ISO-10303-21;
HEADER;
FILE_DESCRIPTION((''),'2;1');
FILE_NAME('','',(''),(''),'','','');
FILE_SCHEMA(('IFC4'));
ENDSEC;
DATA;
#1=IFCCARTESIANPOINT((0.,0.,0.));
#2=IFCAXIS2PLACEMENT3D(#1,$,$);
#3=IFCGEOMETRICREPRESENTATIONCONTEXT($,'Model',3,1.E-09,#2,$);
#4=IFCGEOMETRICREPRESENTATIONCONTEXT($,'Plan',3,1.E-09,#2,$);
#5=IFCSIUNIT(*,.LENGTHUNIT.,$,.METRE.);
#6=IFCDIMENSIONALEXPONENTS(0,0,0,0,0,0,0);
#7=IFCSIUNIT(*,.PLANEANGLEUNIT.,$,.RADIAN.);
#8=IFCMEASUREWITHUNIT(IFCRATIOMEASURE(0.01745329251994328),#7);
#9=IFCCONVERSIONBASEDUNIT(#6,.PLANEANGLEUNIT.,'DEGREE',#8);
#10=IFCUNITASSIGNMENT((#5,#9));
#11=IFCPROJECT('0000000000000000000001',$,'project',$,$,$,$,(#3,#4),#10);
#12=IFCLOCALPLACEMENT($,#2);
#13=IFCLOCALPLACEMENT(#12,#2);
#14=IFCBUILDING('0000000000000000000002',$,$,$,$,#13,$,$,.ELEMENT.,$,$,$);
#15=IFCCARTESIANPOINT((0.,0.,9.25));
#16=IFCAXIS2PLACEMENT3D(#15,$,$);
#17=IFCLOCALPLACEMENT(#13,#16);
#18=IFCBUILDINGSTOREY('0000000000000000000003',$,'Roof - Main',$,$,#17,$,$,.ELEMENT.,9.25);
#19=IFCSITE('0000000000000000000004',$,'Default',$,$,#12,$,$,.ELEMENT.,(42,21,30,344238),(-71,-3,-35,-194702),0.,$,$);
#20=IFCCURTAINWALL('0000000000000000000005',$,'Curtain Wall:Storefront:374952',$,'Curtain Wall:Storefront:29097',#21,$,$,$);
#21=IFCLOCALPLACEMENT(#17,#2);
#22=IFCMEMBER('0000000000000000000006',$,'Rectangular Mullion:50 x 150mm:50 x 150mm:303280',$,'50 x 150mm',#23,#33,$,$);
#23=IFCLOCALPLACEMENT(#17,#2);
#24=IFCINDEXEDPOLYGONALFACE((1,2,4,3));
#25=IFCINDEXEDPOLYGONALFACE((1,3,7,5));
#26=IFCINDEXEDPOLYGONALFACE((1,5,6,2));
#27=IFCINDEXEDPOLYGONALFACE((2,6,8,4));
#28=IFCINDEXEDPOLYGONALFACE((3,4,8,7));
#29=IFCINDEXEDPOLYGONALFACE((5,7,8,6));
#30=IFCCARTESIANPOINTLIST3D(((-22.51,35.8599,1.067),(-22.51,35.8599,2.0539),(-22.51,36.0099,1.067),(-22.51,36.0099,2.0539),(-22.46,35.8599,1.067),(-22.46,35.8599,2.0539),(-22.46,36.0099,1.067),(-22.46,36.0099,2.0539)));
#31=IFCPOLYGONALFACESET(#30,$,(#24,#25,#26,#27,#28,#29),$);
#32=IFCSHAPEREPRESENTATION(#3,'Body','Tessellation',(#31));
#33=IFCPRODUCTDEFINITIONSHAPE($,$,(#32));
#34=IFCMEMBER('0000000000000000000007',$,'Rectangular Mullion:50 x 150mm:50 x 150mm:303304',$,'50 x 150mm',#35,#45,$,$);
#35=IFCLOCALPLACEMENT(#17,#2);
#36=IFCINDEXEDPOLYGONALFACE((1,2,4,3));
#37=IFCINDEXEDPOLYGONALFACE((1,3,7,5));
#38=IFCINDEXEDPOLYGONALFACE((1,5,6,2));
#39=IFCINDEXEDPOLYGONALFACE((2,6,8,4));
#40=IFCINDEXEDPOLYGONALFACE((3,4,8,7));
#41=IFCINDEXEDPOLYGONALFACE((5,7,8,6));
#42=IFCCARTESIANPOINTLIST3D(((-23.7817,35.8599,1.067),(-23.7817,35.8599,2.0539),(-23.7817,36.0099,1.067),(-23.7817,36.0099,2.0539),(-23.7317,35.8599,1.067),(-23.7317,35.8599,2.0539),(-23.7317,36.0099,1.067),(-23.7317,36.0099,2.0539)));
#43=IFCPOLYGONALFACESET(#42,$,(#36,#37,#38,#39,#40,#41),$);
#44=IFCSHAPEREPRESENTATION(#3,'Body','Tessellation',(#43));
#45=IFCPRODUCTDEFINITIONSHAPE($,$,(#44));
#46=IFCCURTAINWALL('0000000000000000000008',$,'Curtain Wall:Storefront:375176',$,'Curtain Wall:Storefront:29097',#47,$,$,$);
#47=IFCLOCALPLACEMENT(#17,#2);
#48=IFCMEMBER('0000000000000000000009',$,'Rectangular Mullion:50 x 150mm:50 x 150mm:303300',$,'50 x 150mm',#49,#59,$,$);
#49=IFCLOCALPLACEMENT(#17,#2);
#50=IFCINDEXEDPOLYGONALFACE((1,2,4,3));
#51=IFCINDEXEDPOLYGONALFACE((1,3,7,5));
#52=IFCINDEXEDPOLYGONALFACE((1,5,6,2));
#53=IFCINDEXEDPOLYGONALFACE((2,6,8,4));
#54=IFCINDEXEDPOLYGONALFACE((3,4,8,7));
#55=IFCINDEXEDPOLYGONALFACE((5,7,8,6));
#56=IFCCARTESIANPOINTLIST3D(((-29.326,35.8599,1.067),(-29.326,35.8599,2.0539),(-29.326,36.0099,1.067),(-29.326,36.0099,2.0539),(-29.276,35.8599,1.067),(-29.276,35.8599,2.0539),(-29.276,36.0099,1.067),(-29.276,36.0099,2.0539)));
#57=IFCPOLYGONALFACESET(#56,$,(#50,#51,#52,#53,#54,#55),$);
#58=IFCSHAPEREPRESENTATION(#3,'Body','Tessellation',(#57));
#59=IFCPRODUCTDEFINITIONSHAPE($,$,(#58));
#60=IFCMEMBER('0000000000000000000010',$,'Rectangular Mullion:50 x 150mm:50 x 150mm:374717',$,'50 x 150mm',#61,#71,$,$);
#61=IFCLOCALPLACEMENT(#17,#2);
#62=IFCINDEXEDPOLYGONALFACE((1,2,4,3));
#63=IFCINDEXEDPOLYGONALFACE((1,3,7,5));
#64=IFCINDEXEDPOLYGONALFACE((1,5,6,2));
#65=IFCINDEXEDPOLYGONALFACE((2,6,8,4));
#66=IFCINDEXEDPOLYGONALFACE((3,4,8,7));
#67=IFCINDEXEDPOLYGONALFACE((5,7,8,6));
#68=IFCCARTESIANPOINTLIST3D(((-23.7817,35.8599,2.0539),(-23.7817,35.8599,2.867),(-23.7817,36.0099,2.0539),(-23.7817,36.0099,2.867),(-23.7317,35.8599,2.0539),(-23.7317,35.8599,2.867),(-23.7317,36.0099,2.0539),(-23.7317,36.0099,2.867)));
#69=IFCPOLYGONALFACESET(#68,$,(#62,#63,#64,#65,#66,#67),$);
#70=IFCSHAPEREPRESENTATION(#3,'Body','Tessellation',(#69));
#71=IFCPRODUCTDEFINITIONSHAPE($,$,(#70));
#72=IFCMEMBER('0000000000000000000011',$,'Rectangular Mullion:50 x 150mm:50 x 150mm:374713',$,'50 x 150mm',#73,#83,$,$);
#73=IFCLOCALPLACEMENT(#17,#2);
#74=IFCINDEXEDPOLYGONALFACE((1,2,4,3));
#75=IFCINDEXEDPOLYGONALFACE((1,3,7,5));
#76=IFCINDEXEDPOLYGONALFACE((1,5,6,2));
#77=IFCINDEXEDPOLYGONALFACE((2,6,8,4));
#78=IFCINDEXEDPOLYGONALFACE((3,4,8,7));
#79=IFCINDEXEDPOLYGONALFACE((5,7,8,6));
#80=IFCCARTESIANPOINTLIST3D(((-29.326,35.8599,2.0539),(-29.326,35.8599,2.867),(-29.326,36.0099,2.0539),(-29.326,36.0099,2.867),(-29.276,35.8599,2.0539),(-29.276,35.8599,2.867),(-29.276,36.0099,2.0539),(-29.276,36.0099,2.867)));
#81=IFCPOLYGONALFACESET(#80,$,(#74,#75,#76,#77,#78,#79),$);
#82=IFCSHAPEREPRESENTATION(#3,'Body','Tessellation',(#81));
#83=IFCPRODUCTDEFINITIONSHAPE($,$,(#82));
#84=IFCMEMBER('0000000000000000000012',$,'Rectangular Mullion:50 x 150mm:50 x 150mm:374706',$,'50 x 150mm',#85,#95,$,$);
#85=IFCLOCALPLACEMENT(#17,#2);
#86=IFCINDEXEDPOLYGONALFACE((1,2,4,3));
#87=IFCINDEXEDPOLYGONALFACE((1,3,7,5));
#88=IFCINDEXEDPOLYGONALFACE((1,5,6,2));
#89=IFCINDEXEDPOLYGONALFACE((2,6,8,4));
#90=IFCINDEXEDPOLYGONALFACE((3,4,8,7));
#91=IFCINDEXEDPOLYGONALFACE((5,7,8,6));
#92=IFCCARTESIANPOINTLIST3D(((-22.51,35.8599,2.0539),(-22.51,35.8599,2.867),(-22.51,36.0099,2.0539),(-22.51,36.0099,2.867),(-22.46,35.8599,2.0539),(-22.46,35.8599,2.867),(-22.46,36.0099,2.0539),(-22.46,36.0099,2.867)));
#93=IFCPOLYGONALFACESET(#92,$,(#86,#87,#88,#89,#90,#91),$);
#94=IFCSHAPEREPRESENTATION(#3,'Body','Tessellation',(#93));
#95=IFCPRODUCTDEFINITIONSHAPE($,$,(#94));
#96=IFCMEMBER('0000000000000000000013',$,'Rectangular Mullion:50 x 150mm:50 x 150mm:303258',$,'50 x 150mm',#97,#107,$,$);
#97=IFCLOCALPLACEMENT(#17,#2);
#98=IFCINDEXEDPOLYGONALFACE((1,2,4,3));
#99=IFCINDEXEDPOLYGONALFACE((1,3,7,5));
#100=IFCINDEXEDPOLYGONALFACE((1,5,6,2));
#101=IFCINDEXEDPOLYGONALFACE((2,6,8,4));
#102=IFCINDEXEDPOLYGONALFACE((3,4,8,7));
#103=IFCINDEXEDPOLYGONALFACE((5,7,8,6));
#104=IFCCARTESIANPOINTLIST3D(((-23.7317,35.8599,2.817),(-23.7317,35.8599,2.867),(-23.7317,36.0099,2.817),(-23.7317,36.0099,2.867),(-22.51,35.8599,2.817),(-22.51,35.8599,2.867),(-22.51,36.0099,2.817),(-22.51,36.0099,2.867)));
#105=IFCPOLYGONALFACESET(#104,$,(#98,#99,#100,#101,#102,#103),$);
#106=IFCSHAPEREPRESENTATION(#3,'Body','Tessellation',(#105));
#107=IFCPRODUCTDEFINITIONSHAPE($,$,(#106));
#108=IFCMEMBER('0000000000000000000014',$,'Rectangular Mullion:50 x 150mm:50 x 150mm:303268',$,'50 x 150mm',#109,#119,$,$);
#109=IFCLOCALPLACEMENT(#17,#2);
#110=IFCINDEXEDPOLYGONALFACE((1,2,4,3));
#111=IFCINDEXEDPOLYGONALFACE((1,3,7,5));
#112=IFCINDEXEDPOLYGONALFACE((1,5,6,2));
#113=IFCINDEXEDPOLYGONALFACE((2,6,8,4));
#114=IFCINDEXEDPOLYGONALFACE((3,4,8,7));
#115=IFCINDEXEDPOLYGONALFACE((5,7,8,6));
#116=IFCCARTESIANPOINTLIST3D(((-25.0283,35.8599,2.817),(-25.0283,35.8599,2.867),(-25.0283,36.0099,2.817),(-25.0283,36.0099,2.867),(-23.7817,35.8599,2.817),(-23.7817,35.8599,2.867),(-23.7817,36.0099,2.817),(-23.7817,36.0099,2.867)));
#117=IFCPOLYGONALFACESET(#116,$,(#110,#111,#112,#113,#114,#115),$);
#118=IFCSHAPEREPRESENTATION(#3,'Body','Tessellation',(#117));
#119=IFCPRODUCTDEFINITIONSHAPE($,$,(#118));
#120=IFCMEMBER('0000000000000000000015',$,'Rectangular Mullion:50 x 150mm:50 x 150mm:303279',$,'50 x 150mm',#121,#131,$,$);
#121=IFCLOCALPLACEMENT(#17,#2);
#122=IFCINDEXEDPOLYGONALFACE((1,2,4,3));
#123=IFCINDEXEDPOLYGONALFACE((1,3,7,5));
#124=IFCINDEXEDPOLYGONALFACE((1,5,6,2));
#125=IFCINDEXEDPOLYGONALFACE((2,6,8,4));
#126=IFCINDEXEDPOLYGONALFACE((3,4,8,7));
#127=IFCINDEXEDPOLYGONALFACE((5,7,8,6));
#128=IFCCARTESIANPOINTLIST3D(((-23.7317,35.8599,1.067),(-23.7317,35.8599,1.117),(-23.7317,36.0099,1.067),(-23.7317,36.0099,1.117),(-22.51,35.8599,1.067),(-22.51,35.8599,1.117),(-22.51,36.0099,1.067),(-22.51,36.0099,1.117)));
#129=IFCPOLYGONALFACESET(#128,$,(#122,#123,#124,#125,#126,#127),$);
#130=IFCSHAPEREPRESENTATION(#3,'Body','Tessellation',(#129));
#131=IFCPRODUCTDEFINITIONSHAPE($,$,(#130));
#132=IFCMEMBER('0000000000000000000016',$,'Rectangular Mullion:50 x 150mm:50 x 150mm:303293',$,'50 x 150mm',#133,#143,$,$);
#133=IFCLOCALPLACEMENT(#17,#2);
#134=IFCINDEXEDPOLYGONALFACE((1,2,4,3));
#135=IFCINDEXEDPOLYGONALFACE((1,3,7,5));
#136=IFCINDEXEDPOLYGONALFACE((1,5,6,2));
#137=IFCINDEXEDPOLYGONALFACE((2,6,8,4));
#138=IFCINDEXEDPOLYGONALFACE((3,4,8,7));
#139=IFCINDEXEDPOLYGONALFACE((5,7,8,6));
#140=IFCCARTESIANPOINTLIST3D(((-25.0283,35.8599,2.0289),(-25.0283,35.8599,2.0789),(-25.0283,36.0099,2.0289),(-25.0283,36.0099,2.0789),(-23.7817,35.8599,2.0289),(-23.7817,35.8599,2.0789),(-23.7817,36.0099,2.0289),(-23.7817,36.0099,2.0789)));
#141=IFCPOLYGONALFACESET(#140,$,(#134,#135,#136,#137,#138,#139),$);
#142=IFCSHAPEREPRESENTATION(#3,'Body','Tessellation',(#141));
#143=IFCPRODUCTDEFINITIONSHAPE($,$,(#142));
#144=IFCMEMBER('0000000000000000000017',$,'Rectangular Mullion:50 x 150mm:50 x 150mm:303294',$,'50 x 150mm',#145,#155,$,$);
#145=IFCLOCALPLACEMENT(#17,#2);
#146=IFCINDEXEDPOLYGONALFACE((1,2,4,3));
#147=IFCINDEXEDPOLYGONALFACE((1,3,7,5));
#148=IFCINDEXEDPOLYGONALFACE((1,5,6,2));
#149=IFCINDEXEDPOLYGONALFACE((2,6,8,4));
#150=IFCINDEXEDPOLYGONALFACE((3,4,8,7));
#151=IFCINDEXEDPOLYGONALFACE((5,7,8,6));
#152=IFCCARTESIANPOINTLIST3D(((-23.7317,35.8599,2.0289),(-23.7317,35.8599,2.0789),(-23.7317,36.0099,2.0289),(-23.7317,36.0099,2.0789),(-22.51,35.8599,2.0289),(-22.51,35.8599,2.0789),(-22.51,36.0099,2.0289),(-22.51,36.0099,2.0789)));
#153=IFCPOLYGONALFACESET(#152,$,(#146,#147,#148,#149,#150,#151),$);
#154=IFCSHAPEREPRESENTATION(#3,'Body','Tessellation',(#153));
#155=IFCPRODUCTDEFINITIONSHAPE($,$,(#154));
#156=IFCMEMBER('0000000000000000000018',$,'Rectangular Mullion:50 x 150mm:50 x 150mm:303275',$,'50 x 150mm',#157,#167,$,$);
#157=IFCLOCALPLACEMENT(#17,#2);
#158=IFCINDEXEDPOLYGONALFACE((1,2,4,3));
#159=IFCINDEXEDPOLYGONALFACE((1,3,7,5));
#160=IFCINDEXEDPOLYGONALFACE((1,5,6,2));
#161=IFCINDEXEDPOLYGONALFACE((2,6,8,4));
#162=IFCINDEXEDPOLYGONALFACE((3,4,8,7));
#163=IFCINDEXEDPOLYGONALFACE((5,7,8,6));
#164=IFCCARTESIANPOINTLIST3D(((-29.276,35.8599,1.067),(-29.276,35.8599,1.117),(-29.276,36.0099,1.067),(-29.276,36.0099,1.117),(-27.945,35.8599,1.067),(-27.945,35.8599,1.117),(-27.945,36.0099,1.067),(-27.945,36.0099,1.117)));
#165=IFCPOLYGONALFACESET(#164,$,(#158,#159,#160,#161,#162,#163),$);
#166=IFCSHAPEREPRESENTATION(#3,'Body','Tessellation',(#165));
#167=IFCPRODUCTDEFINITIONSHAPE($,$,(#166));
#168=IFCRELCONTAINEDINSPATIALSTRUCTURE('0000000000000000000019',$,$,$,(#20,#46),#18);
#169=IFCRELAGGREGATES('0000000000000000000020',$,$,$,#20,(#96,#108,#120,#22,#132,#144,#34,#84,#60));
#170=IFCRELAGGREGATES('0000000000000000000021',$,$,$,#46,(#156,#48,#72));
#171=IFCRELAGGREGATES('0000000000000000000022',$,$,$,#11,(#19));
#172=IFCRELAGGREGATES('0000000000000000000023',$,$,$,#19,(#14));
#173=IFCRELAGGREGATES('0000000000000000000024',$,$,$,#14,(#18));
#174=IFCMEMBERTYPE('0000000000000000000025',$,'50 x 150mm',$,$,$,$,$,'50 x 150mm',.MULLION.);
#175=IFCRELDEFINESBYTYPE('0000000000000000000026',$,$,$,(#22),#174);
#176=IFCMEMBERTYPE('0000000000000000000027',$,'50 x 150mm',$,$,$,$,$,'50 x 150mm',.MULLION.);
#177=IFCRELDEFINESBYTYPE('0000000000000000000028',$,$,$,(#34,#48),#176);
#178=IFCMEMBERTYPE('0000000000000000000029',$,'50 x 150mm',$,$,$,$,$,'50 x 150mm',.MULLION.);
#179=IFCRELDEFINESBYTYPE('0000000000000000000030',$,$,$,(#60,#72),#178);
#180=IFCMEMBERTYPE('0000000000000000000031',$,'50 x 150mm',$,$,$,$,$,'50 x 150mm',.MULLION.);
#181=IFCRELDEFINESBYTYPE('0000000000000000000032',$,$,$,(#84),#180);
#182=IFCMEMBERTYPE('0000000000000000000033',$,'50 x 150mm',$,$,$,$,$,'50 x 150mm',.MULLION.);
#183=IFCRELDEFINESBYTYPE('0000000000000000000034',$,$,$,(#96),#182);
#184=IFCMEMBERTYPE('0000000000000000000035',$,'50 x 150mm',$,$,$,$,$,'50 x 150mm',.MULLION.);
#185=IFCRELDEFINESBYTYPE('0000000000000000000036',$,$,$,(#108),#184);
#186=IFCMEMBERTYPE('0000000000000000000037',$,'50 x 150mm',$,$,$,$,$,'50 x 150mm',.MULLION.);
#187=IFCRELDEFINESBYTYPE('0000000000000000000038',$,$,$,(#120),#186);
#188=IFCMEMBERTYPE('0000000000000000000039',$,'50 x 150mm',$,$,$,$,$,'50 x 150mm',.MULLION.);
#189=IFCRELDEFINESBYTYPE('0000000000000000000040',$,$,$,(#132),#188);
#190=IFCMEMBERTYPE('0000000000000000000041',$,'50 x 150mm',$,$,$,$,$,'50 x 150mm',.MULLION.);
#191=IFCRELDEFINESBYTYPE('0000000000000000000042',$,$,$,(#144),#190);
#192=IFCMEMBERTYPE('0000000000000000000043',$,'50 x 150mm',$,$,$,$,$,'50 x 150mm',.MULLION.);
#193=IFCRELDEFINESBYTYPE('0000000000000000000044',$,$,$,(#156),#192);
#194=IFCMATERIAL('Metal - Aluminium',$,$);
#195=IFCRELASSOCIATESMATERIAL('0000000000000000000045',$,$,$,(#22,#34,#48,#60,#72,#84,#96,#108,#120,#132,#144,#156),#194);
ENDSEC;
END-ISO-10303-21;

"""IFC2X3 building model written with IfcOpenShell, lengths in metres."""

from ifc_helpers import new_model, entity, si_unit, converted_unit, frame, origin, origin_2d_with_axis, place, context, project, spatial, rectangle, extrude, source, transform, mapped, material, type_object, type_shapes, element, aggregate, save


model = new_model("IFC2X3")

# Units and contexts
model_context = context("Model", 3, precision=1e-09, world=origin())
plan_context = context("Plan", 3, precision=1e-09, world=origin())
ifc_project = project(units=[si_unit("LENGTHUNIT", "METRE"), converted_unit("PLANEANGLEUNIT", "DEGREE", entity("IfcRatioMeasure", 0.01745329251994328), si_unit("PLANEANGLEUNIT", "RADIAN"), dimensions=[0, 0, 0, 0, 0, 0, 0])], contexts=[model_context, plan_context])

# Site, building, storey
site_placement = place(None, origin())
site = spatial("IfcSite", under=ifc_project, at=site_placement, Name="Default", CompositionType="ELEMENT", RefLatitude=(42, 21, 30, 344238), RefLongitude=(-71, -3, -35, -194702), RefElevation=0.0)
building_placement = place(site_placement, origin())
building = spatial("IfcBuilding", under=site, at=building_placement, CompositionType="ELEMENT")
storey_placement = place(building_placement, frame((0.0, 0.0, 9.25)))
storey = spatial("IfcBuildingStorey", under=building, at=storey_placement, Name="Roof - Main", CompositionType="ELEMENT", Elevation=9.25)

# Curtain wall, members
ifc_material_1 = material(Name="Metal - Aluminium")
curtain_wall_1_placement = place(storey_placement, origin())
curtain_wall_1 = element("IfcCurtainWall", 1, at=curtain_wall_1_placement, inside=storey, Name="Curtain Wall:Storefront:374952", ObjectType="Curtain Wall:Storefront:29097")
member_type_1 = type_object("IfcMemberType", Name="50 x 150mm", ElementType="50 x 150mm", PredefinedType="MULLION")
shared_shape_1 = source(origin(), model_context, "Body", "SweptSolid", [
    extrude(rectangle(XDim=0.05, YDim=0.15, at=origin_2d_with_axis()), frame((-0.025, 0.0, -0.9869), z_axis=(0.0, 0.0, 1.0), x_axis=(-1.0, 0.0, 0.0)), (0.0, 0.0, 1.0), 0.9869),
])
type_shapes(member_type_1, [shared_shape_1])
member_1_placement = place(storey_placement, frame((-22.46, 35.9349, 1.067), z_axis=(0.0, 0.0, -1.0), x_axis=(1.0, 0.0, 0.0)))
member_1 = element("IfcMember", 2, at=member_1_placement, type_object=member_type_1, material=ifc_material_1, Name="Rectangular Mullion:50 x 150mm:50 x 150mm:303280", ObjectType="50 x 150mm", context=model_context, shape_type="MappedRepresentation", body=[
    mapped(shared_shape_1, transform((0.0, 0.0, 0.0), scale=1.0)),
])
member_type_2 = type_object("IfcMemberType", Name="50 x 150mm", ElementType="50 x 150mm", PredefinedType="MULLION")
shared_shape_2 = source(origin(), model_context, "Body", "SweptSolid", [
    extrude(rectangle(XDim=0.05, YDim=0.15, at=origin_2d_with_axis()), frame((0.0, 0.0, -0.9869), z_axis=(0.0, 0.0, 1.0), x_axis=(-1.0, 0.0, 0.0)), (0.0, 0.0, 1.0), 0.9869),
])
type_shapes(member_type_2, [shared_shape_2])
member_2_placement = place(storey_placement, frame((-23.7567, 35.9349, 1.067), z_axis=(0.0, 0.0, -1.0), x_axis=(1.0, 0.0, 0.0)))
member_2 = element("IfcMember", 3, at=member_2_placement, type_object=member_type_2, material=ifc_material_1, Name="Rectangular Mullion:50 x 150mm:50 x 150mm:303304", ObjectType="50 x 150mm", context=model_context, shape_type="MappedRepresentation", body=[
    mapped(shared_shape_2, transform((0.0, 0.0, 0.0), scale=1.0)),
])

# Curtain wall, member
curtain_wall_2_placement = place(storey_placement, origin())
curtain_wall_2 = element("IfcCurtainWall", 4, at=curtain_wall_2_placement, inside=storey, Name="Curtain Wall:Storefront:375176", ObjectType="Curtain Wall:Storefront:29097")
member_3_placement = place(storey_placement, frame((-29.301, 35.9349, 1.067), z_axis=(0.0, 0.0, -1.0), x_axis=(1.0, 0.0, 0.0)))
member_3 = element("IfcMember", 5, at=member_3_placement, type_object=member_type_2, material=ifc_material_1, Name="Rectangular Mullion:50 x 150mm:50 x 150mm:303300", ObjectType="50 x 150mm", context=model_context, shape_type="MappedRepresentation", body=[
    mapped(shared_shape_2, transform((0.0, 0.0, 0.0), scale=1.0)),
])

# Members
member_type_3 = type_object("IfcMemberType", Name="50 x 150mm", ElementType="50 x 150mm", PredefinedType="MULLION")
shared_shape_3 = source(origin(), model_context, "Body", "SweptSolid", [
    extrude(rectangle(XDim=0.05, YDim=0.15, at=origin_2d_with_axis()), frame((0.0, 0.0, -0.8131), z_axis=(0.0, 0.0, 1.0), x_axis=(-1.0, 0.0, 0.0)), (0.0, 0.0, 1.0), 0.8131),
])
type_shapes(member_type_3, [shared_shape_3])
member_4_placement = place(storey_placement, frame((-23.7567, 35.9349, 2.0539), z_axis=(0.0, 0.0, -1.0), x_axis=(1.0, 0.0, 0.0)))
member_4 = element("IfcMember", 6, at=member_4_placement, type_object=member_type_3, material=ifc_material_1, Name="Rectangular Mullion:50 x 150mm:50 x 150mm:374717", ObjectType="50 x 150mm", context=model_context, shape_type="MappedRepresentation", body=[
    mapped(shared_shape_3, transform((0.0, 0.0, 0.0), scale=1.0)),
])
member_5_placement = place(storey_placement, frame((-29.301, 35.9349, 2.0539), z_axis=(0.0, 0.0, -1.0), x_axis=(1.0, 0.0, 0.0)))
member_5 = element("IfcMember", 7, at=member_5_placement, type_object=member_type_3, material=ifc_material_1, Name="Rectangular Mullion:50 x 150mm:50 x 150mm:374713", ObjectType="50 x 150mm", context=model_context, shape_type="MappedRepresentation", body=[
    mapped(shared_shape_3, transform((0.0, 0.0, 0.0), scale=1.0)),
])
member_type_4 = type_object("IfcMemberType", Name="50 x 150mm", ElementType="50 x 150mm", PredefinedType="MULLION")
shared_shape_4 = source(origin(), model_context, "Body", "SweptSolid", [
    extrude(rectangle(XDim=0.05, YDim=0.15, at=origin_2d_with_axis()), frame((-0.025, 0.0, -0.8131), z_axis=(0.0, 0.0, 1.0), x_axis=(-1.0, 0.0, 0.0)), (0.0, 0.0, 1.0), 0.8131),
])
type_shapes(member_type_4, [shared_shape_4])
member_6_placement = place(storey_placement, frame((-22.46, 35.9349, 2.0539), z_axis=(0.0, 0.0, -1.0), x_axis=(1.0, 0.0, 0.0)))
member_6 = element("IfcMember", 8, at=member_6_placement, type_object=member_type_4, material=ifc_material_1, Name="Rectangular Mullion:50 x 150mm:50 x 150mm:374706", ObjectType="50 x 150mm", context=model_context, shape_type="MappedRepresentation", body=[
    mapped(shared_shape_4, transform((0.0, 0.0, 0.0), scale=1.0)),
])
member_type_5 = type_object("IfcMemberType", Name="50 x 150mm", ElementType="50 x 150mm", PredefinedType="MULLION")
shared_shape_5 = source(origin(), model_context, "Body", "SweptSolid", [
    extrude(rectangle(XDim=0.05, YDim=0.15, at=origin_2d_with_axis()), frame((-0.025, 0.0, -1.2217), z_axis=(0.0, 0.0, 1.0), x_axis=(-1.0, 0.0, 0.0)), (0.0, 0.0, 1.0), 1.2217),
])
type_shapes(member_type_5, [shared_shape_5])
member_7_placement = place(storey_placement, frame((-22.51, 35.9349, 2.867), z_axis=(1.0, 0.0, 0.0), x_axis=(0.0, 0.0, 1.0)))
member_7 = element("IfcMember", 9, at=member_7_placement, type_object=member_type_5, material=ifc_material_1, Name="Rectangular Mullion:50 x 150mm:50 x 150mm:303258", ObjectType="50 x 150mm", context=model_context, shape_type="MappedRepresentation", body=[
    mapped(shared_shape_5, transform((0.0, 0.0, 0.0), scale=1.0)),
])
member_type_6 = type_object("IfcMemberType", Name="50 x 150mm", ElementType="50 x 150mm", PredefinedType="MULLION")
shared_shape_6 = source(origin(), model_context, "Body", "SweptSolid", [
    extrude(rectangle(XDim=0.05, YDim=0.15, at=origin_2d_with_axis()), frame((-0.025, 0.0, -1.2467), z_axis=(0.0, 0.0, 1.0), x_axis=(-1.0, 0.0, 0.0)), (0.0, 0.0, 1.0), 1.2467),
])
type_shapes(member_type_6, [shared_shape_6])
member_8_placement = place(storey_placement, frame((-23.7817, 35.9349, 2.867), z_axis=(1.0, 0.0, 0.0), x_axis=(0.0, 0.0, 1.0)))
member_8 = element("IfcMember", 10, at=member_8_placement, type_object=member_type_6, material=ifc_material_1, Name="Rectangular Mullion:50 x 150mm:50 x 150mm:303268", ObjectType="50 x 150mm", context=model_context, shape_type="MappedRepresentation", body=[
    mapped(shared_shape_6, transform((0.0, 0.0, 0.0), scale=1.0)),
])
member_type_7 = type_object("IfcMemberType", Name="50 x 150mm", ElementType="50 x 150mm", PredefinedType="MULLION")
shared_shape_7 = source(origin(), model_context, "Body", "SweptSolid", [
    extrude(rectangle(XDim=0.05, YDim=0.15, at=origin_2d_with_axis()), frame((-0.025, 0.0, -1.2217), z_axis=(0.0, 0.0, 1.0), x_axis=(-1.0, 0.0, 0.0)), (0.0, 0.0, 1.0), 1.2217),
])
type_shapes(member_type_7, [shared_shape_7])
member_9_placement = place(storey_placement, frame((-23.7317, 35.9349, 1.067), z_axis=(-1.0, 0.0, 0.0), x_axis=(0.0, 0.0, -1.0)))
member_9 = element("IfcMember", 11, at=member_9_placement, type_object=member_type_7, material=ifc_material_1, Name="Rectangular Mullion:50 x 150mm:50 x 150mm:303279", ObjectType="50 x 150mm", context=model_context, shape_type="MappedRepresentation", body=[
    mapped(shared_shape_7, transform((0.0, 0.0, 0.0), scale=1.0)),
])
member_type_8 = type_object("IfcMemberType", Name="50 x 150mm", ElementType="50 x 150mm", PredefinedType="MULLION")
shared_shape_8 = source(origin(), model_context, "Body", "SweptSolid", [
    extrude(rectangle(XDim=0.05, YDim=0.15, at=origin_2d_with_axis()), frame((0.0, 0.0, -1.2467), z_axis=(0.0, 0.0, 1.0), x_axis=(-1.0, 0.0, 0.0)), (0.0, 0.0, 1.0), 1.2467),
])
type_shapes(member_type_8, [shared_shape_8])
member_10_placement = place(storey_placement, frame((-23.7817, 35.9349, 2.0539), z_axis=(1.0, 0.0, 0.0), x_axis=(0.0, 0.0, 1.0)))
member_10 = element("IfcMember", 12, at=member_10_placement, type_object=member_type_8, material=ifc_material_1, Name="Rectangular Mullion:50 x 150mm:50 x 150mm:303293", ObjectType="50 x 150mm", context=model_context, shape_type="MappedRepresentation", body=[
    mapped(shared_shape_8, transform((0.0, 0.0, 0.0), scale=1.0)),
])
member_type_9 = type_object("IfcMemberType", Name="50 x 150mm", ElementType="50 x 150mm", PredefinedType="MULLION")
shared_shape_9 = source(origin(), model_context, "Body", "SweptSolid", [
    extrude(rectangle(XDim=0.05, YDim=0.15, at=origin_2d_with_axis()), frame((0.0, 0.0, -1.2217), z_axis=(0.0, 0.0, 1.0), x_axis=(-1.0, 0.0, 0.0)), (0.0, 0.0, 1.0), 1.2217),
])
type_shapes(member_type_9, [shared_shape_9])
member_11_placement = place(storey_placement, frame((-22.51, 35.9349, 2.0539), z_axis=(1.0, 0.0, 0.0), x_axis=(0.0, 0.0, 1.0)))
member_11 = element("IfcMember", 13, at=member_11_placement, type_object=member_type_9, material=ifc_material_1, Name="Rectangular Mullion:50 x 150mm:50 x 150mm:303294", ObjectType="50 x 150mm", context=model_context, shape_type="MappedRepresentation", body=[
    mapped(shared_shape_9, transform((0.0, 0.0, 0.0), scale=1.0)),
])
member_type_10 = type_object("IfcMemberType", Name="50 x 150mm", ElementType="50 x 150mm", PredefinedType="MULLION")
shared_shape_10 = source(origin(), model_context, "Body", "SweptSolid", [
    extrude(rectangle(XDim=0.05, YDim=0.15, at=origin_2d_with_axis()), frame((-0.025, 0.0, -1.331), z_axis=(0.0, 0.0, 1.0), x_axis=(-1.0, 0.0, 0.0)), (0.0, 0.0, 1.0), 1.331),
])
type_shapes(member_type_10, [shared_shape_10])
member_12_placement = place(storey_placement, frame((-29.276, 35.9349, 1.067), z_axis=(-1.0, 0.0, 0.0), x_axis=(0.0, 0.0, -1.0)))
member_12 = element("IfcMember", 14, at=member_12_placement, type_object=member_type_10, material=ifc_material_1, Name="Rectangular Mullion:50 x 150mm:50 x 150mm:303275", ObjectType="50 x 150mm", context=model_context, shape_type="MappedRepresentation", body=[
    mapped(shared_shape_10, transform((0.0, 0.0, 0.0), scale=1.0)),
])

aggregate(curtain_wall_1, [member_7, member_8, member_9, member_1, member_10, member_11, member_2, member_6, member_4])
aggregate(curtain_wall_2, [member_12, member_3, member_5])

save(model, "model.ifc")
